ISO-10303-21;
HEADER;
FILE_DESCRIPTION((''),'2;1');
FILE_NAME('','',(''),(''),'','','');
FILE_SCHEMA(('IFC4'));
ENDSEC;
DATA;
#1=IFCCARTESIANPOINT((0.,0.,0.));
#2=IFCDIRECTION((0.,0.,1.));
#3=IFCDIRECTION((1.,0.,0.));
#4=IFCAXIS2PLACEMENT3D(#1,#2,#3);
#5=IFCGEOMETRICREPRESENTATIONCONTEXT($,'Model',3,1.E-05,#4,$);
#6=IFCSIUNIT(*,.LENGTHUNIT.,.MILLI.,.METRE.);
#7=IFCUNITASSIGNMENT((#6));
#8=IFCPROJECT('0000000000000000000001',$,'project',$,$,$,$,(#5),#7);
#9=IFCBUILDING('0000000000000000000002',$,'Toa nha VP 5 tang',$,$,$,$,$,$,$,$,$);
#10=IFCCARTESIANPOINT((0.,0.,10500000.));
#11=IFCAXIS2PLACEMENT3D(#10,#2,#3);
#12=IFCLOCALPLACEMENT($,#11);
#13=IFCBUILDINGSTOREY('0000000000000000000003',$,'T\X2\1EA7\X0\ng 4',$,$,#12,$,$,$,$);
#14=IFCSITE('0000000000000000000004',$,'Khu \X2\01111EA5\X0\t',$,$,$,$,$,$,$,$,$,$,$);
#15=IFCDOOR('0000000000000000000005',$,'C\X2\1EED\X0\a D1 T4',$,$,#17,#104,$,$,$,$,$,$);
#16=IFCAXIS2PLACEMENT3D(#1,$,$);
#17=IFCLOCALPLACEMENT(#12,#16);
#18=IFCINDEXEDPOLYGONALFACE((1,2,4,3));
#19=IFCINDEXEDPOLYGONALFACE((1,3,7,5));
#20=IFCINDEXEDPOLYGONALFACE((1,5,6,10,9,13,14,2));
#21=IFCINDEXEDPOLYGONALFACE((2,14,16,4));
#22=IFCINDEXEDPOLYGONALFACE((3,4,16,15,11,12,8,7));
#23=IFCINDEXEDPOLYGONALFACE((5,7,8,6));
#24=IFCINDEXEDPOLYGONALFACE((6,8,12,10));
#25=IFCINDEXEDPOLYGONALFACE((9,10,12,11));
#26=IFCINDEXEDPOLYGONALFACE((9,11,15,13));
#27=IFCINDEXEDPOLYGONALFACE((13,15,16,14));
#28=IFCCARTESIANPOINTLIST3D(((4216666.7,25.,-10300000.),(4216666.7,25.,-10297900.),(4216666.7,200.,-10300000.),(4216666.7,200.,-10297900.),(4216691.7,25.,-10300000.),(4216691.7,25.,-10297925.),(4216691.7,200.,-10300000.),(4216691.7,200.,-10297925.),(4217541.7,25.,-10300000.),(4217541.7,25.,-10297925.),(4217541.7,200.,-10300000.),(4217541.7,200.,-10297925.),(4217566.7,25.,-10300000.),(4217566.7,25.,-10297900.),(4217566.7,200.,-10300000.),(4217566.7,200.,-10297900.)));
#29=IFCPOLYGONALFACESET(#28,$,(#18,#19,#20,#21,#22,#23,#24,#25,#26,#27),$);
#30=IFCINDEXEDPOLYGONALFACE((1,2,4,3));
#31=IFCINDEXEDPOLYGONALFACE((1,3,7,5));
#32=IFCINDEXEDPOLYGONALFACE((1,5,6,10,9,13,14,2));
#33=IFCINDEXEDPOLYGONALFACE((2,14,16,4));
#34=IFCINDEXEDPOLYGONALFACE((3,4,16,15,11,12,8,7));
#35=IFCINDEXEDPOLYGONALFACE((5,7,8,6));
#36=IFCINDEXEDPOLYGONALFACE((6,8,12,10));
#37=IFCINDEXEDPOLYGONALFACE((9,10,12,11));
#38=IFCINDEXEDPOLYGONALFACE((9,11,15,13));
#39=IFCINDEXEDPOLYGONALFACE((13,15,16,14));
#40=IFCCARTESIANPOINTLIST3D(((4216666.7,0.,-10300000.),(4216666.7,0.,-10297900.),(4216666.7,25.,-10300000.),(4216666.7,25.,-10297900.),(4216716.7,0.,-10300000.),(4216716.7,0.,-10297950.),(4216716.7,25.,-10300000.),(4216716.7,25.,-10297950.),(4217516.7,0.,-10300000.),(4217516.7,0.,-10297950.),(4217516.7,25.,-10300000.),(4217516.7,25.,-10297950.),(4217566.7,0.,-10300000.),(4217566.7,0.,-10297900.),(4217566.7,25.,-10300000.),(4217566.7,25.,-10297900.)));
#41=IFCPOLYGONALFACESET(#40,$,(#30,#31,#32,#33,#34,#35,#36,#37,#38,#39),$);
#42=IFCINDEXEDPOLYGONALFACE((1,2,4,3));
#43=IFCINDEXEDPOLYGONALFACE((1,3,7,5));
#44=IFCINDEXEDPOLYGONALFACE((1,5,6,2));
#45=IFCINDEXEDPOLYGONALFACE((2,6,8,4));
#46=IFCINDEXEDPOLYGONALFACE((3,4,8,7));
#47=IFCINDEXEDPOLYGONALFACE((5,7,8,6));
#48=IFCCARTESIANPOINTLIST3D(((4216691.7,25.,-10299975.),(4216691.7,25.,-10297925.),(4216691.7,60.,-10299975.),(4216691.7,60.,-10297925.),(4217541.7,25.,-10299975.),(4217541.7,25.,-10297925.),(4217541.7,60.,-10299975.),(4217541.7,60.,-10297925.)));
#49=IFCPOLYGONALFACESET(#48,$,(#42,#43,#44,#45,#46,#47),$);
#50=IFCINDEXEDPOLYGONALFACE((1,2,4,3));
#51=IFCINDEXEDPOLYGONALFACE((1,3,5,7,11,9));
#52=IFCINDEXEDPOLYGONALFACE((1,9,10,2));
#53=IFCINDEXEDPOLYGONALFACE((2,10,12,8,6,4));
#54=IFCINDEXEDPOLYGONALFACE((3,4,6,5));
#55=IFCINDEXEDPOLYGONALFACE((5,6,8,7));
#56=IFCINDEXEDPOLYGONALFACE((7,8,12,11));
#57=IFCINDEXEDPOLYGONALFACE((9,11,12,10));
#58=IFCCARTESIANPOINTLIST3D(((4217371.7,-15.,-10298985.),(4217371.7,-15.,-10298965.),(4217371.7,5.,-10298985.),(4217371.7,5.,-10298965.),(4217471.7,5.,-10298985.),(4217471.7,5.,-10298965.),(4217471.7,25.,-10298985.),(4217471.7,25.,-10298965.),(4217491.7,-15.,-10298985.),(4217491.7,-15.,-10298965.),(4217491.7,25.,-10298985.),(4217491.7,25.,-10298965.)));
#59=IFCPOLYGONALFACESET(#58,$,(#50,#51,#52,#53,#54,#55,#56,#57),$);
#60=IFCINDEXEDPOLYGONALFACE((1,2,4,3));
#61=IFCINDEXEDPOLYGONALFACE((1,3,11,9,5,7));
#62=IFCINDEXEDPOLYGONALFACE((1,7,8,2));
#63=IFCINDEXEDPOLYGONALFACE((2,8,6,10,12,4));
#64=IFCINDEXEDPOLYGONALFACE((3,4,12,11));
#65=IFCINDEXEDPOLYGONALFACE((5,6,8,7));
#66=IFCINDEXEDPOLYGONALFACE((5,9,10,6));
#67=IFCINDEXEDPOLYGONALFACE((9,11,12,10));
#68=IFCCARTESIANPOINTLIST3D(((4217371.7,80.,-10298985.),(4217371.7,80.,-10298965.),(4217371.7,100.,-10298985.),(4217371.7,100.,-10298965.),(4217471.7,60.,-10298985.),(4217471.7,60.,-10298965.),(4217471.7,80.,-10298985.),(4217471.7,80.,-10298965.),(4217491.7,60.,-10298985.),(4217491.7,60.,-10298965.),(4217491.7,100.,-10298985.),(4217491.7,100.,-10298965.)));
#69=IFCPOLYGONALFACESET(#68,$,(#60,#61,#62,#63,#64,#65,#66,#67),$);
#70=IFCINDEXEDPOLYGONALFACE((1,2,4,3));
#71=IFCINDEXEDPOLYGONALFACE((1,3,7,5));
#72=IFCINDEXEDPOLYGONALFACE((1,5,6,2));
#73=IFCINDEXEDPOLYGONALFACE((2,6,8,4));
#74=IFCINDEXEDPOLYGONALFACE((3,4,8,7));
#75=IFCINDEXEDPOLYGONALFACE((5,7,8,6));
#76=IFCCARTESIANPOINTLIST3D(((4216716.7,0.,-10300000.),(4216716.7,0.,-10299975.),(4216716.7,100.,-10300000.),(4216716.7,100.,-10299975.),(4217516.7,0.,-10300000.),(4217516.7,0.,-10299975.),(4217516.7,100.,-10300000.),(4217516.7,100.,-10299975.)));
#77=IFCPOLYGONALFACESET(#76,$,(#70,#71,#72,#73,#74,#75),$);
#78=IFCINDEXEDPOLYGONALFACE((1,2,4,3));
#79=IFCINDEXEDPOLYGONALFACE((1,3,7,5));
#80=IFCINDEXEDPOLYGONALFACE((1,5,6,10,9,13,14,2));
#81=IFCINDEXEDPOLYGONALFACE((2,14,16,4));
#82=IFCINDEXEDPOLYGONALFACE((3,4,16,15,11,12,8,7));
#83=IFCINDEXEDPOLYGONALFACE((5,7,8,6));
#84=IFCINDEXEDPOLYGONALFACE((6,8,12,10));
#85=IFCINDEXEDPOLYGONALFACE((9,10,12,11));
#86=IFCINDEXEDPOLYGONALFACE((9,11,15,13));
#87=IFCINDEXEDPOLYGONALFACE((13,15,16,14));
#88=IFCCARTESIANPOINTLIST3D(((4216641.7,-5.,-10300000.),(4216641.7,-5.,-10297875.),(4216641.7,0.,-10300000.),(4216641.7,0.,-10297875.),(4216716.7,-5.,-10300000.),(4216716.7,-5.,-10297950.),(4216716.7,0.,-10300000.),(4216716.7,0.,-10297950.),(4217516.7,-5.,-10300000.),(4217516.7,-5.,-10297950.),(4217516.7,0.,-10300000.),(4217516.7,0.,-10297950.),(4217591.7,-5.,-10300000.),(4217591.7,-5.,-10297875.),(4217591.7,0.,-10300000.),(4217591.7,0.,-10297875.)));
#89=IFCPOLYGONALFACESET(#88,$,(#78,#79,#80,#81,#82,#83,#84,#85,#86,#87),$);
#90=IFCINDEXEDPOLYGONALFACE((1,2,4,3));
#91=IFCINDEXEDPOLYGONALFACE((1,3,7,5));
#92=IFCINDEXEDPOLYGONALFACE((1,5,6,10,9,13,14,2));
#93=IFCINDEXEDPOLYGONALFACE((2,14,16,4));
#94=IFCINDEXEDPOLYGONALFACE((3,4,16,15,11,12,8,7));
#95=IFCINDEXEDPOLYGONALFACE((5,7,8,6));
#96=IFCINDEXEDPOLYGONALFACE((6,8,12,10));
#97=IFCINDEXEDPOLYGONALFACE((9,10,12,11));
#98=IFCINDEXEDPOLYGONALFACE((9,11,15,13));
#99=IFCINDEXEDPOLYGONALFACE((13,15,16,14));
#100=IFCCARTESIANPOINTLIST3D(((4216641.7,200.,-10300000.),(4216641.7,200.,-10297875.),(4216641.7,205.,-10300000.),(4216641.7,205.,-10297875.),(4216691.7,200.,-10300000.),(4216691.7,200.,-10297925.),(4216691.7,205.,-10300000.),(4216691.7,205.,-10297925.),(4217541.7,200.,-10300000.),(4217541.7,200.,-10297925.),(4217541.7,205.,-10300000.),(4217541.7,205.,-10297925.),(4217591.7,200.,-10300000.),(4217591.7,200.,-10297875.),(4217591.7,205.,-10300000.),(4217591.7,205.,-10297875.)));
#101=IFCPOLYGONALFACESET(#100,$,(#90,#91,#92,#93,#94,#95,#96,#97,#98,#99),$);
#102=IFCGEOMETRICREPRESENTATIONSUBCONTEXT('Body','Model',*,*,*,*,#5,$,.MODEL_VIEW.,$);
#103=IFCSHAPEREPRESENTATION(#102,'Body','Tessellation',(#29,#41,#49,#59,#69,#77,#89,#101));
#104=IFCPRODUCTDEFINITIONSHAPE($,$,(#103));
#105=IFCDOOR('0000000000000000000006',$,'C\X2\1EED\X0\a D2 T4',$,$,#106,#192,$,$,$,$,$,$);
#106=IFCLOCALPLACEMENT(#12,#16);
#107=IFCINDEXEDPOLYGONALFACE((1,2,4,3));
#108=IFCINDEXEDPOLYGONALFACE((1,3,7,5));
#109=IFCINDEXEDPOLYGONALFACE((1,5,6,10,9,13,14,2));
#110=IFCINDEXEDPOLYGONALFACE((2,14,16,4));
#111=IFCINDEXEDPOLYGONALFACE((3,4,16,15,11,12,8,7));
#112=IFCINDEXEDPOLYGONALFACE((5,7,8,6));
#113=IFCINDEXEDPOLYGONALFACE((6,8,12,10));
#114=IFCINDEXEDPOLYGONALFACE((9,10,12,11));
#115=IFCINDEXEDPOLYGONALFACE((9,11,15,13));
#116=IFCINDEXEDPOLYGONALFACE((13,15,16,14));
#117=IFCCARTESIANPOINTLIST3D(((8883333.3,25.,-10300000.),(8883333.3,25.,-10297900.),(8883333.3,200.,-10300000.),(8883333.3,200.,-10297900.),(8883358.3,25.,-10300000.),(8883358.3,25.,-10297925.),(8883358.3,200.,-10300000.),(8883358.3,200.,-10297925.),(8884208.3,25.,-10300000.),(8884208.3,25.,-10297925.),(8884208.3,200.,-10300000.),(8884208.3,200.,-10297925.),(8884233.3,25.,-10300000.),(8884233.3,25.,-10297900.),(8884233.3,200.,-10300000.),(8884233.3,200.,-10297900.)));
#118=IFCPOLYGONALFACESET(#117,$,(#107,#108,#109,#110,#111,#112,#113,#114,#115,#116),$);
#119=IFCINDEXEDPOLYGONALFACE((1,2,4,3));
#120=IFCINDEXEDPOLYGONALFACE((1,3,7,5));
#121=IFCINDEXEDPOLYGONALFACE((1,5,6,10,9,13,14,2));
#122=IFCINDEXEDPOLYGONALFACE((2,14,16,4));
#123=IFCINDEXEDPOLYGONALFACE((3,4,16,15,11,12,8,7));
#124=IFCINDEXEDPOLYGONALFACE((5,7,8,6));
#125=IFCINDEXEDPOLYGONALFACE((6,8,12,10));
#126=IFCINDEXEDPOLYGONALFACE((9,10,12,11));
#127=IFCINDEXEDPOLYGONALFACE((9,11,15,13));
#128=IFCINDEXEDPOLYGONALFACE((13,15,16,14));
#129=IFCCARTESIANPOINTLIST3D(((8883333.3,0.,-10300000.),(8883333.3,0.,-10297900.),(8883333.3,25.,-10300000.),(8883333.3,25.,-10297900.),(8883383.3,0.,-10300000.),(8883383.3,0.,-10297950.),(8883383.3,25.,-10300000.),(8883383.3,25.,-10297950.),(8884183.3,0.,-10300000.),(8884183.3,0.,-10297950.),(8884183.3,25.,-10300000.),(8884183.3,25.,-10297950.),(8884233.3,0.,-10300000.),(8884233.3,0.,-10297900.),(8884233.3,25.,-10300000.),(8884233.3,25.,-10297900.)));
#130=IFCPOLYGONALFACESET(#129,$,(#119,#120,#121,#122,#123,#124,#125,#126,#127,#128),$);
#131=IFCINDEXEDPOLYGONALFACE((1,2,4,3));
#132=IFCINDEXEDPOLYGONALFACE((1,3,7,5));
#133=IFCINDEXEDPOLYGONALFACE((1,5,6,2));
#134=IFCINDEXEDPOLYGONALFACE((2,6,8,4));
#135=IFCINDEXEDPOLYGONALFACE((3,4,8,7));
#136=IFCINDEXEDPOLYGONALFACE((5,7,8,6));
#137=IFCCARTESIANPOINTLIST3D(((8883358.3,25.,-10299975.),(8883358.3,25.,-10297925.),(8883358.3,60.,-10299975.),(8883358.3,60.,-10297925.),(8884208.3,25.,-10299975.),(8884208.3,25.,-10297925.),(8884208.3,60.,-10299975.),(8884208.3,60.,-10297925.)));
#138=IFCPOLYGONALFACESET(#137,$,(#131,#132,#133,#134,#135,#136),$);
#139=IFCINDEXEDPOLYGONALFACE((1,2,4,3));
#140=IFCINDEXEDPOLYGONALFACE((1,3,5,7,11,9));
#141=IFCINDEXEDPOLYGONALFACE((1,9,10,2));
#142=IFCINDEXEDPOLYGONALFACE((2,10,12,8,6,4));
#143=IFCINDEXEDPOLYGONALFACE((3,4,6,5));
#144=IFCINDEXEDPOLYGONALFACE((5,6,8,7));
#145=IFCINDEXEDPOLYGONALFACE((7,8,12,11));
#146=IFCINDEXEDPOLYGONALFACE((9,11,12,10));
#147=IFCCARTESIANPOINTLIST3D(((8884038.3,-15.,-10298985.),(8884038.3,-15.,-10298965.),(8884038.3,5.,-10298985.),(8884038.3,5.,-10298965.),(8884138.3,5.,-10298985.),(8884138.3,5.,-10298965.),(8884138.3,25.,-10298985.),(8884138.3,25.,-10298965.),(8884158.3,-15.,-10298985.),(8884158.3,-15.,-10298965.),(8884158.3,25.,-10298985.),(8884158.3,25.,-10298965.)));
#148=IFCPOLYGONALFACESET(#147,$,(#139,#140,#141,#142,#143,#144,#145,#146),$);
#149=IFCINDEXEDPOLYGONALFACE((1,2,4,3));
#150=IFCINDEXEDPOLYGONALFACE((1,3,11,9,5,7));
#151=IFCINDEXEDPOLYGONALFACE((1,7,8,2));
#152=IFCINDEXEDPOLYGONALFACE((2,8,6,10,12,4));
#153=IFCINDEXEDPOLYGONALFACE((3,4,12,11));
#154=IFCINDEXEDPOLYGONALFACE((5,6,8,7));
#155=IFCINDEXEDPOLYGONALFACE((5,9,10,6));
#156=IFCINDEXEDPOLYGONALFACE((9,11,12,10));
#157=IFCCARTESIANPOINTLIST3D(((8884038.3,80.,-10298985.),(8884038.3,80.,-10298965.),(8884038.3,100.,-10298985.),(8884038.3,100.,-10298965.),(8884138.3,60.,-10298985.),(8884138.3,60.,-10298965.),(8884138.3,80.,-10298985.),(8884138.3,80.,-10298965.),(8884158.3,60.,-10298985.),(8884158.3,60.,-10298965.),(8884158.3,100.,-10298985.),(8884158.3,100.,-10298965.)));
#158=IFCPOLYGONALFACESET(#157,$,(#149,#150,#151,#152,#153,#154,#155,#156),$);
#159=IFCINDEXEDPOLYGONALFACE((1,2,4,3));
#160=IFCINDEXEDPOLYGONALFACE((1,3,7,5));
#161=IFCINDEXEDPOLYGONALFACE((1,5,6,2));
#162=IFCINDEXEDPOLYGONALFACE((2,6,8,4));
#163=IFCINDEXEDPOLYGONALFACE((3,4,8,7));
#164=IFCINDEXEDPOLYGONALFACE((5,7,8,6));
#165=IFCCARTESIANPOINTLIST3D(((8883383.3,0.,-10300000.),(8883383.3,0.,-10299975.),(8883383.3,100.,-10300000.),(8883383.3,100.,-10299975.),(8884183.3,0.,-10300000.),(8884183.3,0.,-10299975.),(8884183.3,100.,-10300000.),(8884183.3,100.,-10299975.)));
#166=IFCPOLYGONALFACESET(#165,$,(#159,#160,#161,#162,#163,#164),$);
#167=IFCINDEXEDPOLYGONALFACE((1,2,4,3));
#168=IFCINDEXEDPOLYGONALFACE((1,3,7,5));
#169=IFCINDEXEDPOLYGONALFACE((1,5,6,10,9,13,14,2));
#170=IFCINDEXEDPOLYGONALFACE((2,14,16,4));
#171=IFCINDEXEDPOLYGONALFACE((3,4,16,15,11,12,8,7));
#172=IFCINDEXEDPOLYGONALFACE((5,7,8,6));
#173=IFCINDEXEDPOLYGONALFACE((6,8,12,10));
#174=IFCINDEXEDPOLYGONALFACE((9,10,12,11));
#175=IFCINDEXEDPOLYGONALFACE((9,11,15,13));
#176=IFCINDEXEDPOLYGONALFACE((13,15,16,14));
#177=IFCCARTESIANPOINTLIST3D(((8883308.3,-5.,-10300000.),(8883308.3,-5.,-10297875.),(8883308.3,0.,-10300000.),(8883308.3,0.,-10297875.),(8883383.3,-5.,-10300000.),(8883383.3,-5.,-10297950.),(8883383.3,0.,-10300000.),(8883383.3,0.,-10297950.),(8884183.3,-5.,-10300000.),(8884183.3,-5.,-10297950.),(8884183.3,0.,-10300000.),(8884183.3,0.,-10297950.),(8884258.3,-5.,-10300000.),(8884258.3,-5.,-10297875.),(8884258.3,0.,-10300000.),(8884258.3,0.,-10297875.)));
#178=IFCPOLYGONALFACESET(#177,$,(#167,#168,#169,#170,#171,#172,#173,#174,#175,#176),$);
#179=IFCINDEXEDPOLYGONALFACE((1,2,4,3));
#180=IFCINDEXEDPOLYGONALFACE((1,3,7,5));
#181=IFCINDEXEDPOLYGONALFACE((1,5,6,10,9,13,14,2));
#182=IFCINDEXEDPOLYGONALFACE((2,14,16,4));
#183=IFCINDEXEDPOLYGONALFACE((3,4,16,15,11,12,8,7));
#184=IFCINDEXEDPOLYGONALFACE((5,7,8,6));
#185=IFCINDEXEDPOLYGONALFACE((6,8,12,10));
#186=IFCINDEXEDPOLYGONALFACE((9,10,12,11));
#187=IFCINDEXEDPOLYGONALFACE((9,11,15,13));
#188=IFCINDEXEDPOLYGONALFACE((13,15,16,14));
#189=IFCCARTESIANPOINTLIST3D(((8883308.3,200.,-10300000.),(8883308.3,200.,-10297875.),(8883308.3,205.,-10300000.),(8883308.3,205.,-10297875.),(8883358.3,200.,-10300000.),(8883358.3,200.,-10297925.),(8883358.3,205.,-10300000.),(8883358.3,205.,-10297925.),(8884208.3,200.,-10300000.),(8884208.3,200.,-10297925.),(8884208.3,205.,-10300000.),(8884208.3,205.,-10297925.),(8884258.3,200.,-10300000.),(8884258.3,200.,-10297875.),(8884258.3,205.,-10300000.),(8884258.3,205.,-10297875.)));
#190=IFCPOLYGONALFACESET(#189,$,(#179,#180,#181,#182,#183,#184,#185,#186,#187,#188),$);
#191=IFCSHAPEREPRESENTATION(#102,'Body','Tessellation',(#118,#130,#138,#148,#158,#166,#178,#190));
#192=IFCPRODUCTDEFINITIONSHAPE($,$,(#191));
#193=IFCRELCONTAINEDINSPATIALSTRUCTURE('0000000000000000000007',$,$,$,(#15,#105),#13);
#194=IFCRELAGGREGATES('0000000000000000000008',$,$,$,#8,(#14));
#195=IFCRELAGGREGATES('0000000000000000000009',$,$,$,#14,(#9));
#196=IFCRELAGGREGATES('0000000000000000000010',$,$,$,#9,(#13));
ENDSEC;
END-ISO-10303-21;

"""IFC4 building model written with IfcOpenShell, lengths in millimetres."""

from ifc_helpers import new_model, si_unit, frame, origin_with_axes, place, context, subcontext, project, spatial, line, indexed_curve, outline, extrude, element, save


model = new_model("IFC4")

# Units and contexts
model_context = context("Model", 3, precision=1e-05, world=origin_with_axes())
body_context = subcontext(model_context, "Body", "Model", "MODEL_VIEW")
ifc_project = project(units=[si_unit("LENGTHUNIT", "METRE", prefix="MILLI")], contexts=[model_context])

# Site, building, storey
site = spatial("IfcSite", under=ifc_project, Name="Khu đất")
building = spatial("IfcBuilding", under=site, Name="Toa nha VP 5 tang")
storey_placement = place(None, frame((0.0, 0.0, 10500000.0), z_axis=(0.0, 0.0, 1.0), x_axis=(1.0, 0.0, 0.0)))
storey = spatial("IfcBuildingStorey", under=building, at=storey_placement, Name="Tầng 4")

# Doors
door_1_placement = place(storey_placement, frame((4216666.7, 0.0, -10300000.0), z_axis=(0.0, 0.0, 1.0), x_axis=(1.0, 0.0, 0.0)))
element("IfcDoor", 1, at=door_1_placement, inside=storey, Name="Cửa D1 T4", context=body_context, shape_type="SolidModel", body=[
    extrude(outline(indexed_curve([(0.0, 0.0), (0.0, 2100.0), (900.0, 2100.0), (900.0, 0.0), (875.0, 0.0), (875.0, 2075.0), (25.0, 2075.0), (25.0, 0.0)], segments=[line(1, 2, 3, 4, 5, 6, 7, 8, 1)])), frame((0.0, 25.0, 0.0), z_axis=(0.0, -1.0, 0.0), x_axis=(1.0, 0.0, 0.0)), (0.0, 0.0, -1.0), 175.0),
    extrude(outline(indexed_curve([(0.0, 0.0), (0.0, 2100.0), (900.0, 2100.0), (900.0, 0.0), (850.0, 0.0), (850.0, 2050.0), (50.0, 2050.0), (50.0, 0.0)], segments=[line(1, 2, 3, 4, 5, 6, 7, 8, 1)])), frame((0.0, 0.0, 0.0), z_axis=(0.0, -1.0, 0.0), x_axis=(1.0, 0.0, 0.0)), (0.0, 0.0, -1.0), 25.0),
    extrude(outline(indexed_curve([(0.0, 0.0), (850.0, 0.0), (850.0, 35.0), (0.0, 35.0)], segments=[line(1, 2, 3, 4, 1)])), frame((25.0, 25.0, 25.0), z_axis=(0.0, 0.0, 1.0), x_axis=(1.0, 0.0, 0.0)), (0.0, 0.0, 1.0), 2050.0),
    extrude(outline(indexed_curve([(0.0, 0.0), (0.0, -40.0), (-120.0, -40.0), (-120.0, -20.0), (-20.0, -20.0), (-20.0, 0.0)], segments=[line(1, 2, 3, 4, 5, 6, 1)])), frame((825.0, 25.0, 1015.0), z_axis=(0.0, 0.0, 1.0), x_axis=(1.0, 0.0, 0.0)), (0.0, 0.0, 1.0), 20.0),
    extrude(outline(indexed_curve([(0.0, 0.0), (0.0, 40.0), (-120.0, 40.0), (-120.0, 20.0), (-20.0, 20.0), (-20.0, 0.0)], segments=[line(1, 2, 3, 4, 5, 6, 1)])), frame((825.0, 60.0, 1015.0), z_axis=(0.0, 0.0, 1.0), x_axis=(1.0, 0.0, 0.0)), (0.0, 0.0, 1.0), 20.0),
    extrude(outline(indexed_curve([(0.0, 0.0), (800.0, 0.0), (800.0, 100.0), (0.0, 100.0)], segments=[line(1, 2, 3, 4, 1)])), frame((50.0, 0.0, 0.0), z_axis=(0.0, 0.0, 1.0), x_axis=(1.0, 0.0, 0.0)), (0.0, 0.0, 1.0), 25.0),
    extrude(outline(indexed_curve([(0.0, 0.0), (0.0, 2125.0), (950.0, 2125.0), (950.0, 0.0), (875.0, 0.0), (875.0, 2050.0), (75.0, 2050.0), (75.0, 0.0)], segments=[line(1, 2, 3, 4, 5, 6, 7, 8, 1)])), frame((-25.0, -5.0, 0.0), z_axis=(0.0, -1.0, 0.0), x_axis=(1.0, 0.0, 0.0)), (0.0, 0.0, -1.0), 5.0),
    extrude(outline(indexed_curve([(0.0, 0.0), (0.0, 2125.0), (950.0, 2125.0), (950.0, 0.0), (900.0, 0.0), (900.0, 2075.0), (50.0, 2075.0), (50.0, 0.0)], segments=[line(1, 2, 3, 4, 5, 6, 7, 8, 1)])), frame((-25.0, 200.0, 0.0), z_axis=(0.0, -1.0, 0.0), x_axis=(1.0, 0.0, 0.0)), (0.0, 0.0, -1.0), 5.0),
])
door_2_placement = place(storey_placement, frame((8883333.3, 0.0, -10300000.0), z_axis=(0.0, 0.0, 1.0), x_axis=(1.0, 0.0, 0.0)))
element("IfcDoor", 2, at=door_2_placement, inside=storey, Name="Cửa D2 T4", context=body_context, shape_type="SolidModel", body=[
    extrude(outline(indexed_curve([(0.0, 0.0), (0.0, 2100.0), (900.0, 2100.0), (900.0, 0.0), (875.0, 0.0), (875.0, 2075.0), (25.0, 2075.0), (25.0, 0.0)], segments=[line(1, 2, 3, 4, 5, 6, 7, 8, 1)])), frame((0.0, 25.0, 0.0), z_axis=(0.0, -1.0, 0.0), x_axis=(1.0, 0.0, 0.0)), (0.0, 0.0, -1.0), 175.0),
    extrude(outline(indexed_curve([(0.0, 0.0), (0.0, 2100.0), (900.0, 2100.0), (900.0, 0.0), (850.0, 0.0), (850.0, 2050.0), (50.0, 2050.0), (50.0, 0.0)], segments=[line(1, 2, 3, 4, 5, 6, 7, 8, 1)])), frame((0.0, 0.0, 0.0), z_axis=(0.0, -1.0, 0.0), x_axis=(1.0, 0.0, 0.0)), (0.0, 0.0, -1.0), 25.0),
    extrude(outline(indexed_curve([(0.0, 0.0), (850.0, 0.0), (850.0, 35.0), (0.0, 35.0)], segments=[line(1, 2, 3, 4, 1)])), frame((25.0, 25.0, 25.0), z_axis=(0.0, 0.0, 1.0), x_axis=(1.0, 0.0, 0.0)), (0.0, 0.0, 1.0), 2050.0),
    extrude(outline(indexed_curve([(0.0, 0.0), (0.0, -40.0), (-120.0, -40.0), (-120.0, -20.0), (-20.0, -20.0), (-20.0, 0.0)], segments=[line(1, 2, 3, 4, 5, 6, 1)])), frame((825.0, 25.0, 1015.0), z_axis=(0.0, 0.0, 1.0), x_axis=(1.0, 0.0, 0.0)), (0.0, 0.0, 1.0), 20.0),
    extrude(outline(indexed_curve([(0.0, 0.0), (0.0, 40.0), (-120.0, 40.0), (-120.0, 20.0), (-20.0, 20.0), (-20.0, 0.0)], segments=[line(1, 2, 3, 4, 5, 6, 1)])), frame((825.0, 60.0, 1015.0), z_axis=(0.0, 0.0, 1.0), x_axis=(1.0, 0.0, 0.0)), (0.0, 0.0, 1.0), 20.0),
    extrude(outline(indexed_curve([(0.0, 0.0), (800.0, 0.0), (800.0, 100.0), (0.0, 100.0)], segments=[line(1, 2, 3, 4, 1)])), frame((50.0, 0.0, 0.0), z_axis=(0.0, 0.0, 1.0), x_axis=(1.0, 0.0, 0.0)), (0.0, 0.0, 1.0), 25.0),
    extrude(outline(indexed_curve([(0.0, 0.0), (0.0, 2125.0), (950.0, 2125.0), (950.0, 0.0), (875.0, 0.0), (875.0, 2050.0), (75.0, 2050.0), (75.0, 0.0)], segments=[line(1, 2, 3, 4, 5, 6, 7, 8, 1)])), frame((-25.0, -5.0, 0.0), z_axis=(0.0, -1.0, 0.0), x_axis=(1.0, 0.0, 0.0)), (0.0, 0.0, -1.0), 5.0),
    extrude(outline(indexed_curve([(0.0, 0.0), (0.0, 2125.0), (950.0, 2125.0), (950.0, 0.0), (900.0, 0.0), (900.0, 2075.0), (50.0, 2075.0), (50.0, 0.0)], segments=[line(1, 2, 3, 4, 5, 6, 7, 8, 1)])), frame((-25.0, 200.0, 0.0), z_axis=(0.0, -1.0, 0.0), x_axis=(1.0, 0.0, 0.0)), (0.0, 0.0, -1.0), 5.0),
])

save(model, "model.ifc")
